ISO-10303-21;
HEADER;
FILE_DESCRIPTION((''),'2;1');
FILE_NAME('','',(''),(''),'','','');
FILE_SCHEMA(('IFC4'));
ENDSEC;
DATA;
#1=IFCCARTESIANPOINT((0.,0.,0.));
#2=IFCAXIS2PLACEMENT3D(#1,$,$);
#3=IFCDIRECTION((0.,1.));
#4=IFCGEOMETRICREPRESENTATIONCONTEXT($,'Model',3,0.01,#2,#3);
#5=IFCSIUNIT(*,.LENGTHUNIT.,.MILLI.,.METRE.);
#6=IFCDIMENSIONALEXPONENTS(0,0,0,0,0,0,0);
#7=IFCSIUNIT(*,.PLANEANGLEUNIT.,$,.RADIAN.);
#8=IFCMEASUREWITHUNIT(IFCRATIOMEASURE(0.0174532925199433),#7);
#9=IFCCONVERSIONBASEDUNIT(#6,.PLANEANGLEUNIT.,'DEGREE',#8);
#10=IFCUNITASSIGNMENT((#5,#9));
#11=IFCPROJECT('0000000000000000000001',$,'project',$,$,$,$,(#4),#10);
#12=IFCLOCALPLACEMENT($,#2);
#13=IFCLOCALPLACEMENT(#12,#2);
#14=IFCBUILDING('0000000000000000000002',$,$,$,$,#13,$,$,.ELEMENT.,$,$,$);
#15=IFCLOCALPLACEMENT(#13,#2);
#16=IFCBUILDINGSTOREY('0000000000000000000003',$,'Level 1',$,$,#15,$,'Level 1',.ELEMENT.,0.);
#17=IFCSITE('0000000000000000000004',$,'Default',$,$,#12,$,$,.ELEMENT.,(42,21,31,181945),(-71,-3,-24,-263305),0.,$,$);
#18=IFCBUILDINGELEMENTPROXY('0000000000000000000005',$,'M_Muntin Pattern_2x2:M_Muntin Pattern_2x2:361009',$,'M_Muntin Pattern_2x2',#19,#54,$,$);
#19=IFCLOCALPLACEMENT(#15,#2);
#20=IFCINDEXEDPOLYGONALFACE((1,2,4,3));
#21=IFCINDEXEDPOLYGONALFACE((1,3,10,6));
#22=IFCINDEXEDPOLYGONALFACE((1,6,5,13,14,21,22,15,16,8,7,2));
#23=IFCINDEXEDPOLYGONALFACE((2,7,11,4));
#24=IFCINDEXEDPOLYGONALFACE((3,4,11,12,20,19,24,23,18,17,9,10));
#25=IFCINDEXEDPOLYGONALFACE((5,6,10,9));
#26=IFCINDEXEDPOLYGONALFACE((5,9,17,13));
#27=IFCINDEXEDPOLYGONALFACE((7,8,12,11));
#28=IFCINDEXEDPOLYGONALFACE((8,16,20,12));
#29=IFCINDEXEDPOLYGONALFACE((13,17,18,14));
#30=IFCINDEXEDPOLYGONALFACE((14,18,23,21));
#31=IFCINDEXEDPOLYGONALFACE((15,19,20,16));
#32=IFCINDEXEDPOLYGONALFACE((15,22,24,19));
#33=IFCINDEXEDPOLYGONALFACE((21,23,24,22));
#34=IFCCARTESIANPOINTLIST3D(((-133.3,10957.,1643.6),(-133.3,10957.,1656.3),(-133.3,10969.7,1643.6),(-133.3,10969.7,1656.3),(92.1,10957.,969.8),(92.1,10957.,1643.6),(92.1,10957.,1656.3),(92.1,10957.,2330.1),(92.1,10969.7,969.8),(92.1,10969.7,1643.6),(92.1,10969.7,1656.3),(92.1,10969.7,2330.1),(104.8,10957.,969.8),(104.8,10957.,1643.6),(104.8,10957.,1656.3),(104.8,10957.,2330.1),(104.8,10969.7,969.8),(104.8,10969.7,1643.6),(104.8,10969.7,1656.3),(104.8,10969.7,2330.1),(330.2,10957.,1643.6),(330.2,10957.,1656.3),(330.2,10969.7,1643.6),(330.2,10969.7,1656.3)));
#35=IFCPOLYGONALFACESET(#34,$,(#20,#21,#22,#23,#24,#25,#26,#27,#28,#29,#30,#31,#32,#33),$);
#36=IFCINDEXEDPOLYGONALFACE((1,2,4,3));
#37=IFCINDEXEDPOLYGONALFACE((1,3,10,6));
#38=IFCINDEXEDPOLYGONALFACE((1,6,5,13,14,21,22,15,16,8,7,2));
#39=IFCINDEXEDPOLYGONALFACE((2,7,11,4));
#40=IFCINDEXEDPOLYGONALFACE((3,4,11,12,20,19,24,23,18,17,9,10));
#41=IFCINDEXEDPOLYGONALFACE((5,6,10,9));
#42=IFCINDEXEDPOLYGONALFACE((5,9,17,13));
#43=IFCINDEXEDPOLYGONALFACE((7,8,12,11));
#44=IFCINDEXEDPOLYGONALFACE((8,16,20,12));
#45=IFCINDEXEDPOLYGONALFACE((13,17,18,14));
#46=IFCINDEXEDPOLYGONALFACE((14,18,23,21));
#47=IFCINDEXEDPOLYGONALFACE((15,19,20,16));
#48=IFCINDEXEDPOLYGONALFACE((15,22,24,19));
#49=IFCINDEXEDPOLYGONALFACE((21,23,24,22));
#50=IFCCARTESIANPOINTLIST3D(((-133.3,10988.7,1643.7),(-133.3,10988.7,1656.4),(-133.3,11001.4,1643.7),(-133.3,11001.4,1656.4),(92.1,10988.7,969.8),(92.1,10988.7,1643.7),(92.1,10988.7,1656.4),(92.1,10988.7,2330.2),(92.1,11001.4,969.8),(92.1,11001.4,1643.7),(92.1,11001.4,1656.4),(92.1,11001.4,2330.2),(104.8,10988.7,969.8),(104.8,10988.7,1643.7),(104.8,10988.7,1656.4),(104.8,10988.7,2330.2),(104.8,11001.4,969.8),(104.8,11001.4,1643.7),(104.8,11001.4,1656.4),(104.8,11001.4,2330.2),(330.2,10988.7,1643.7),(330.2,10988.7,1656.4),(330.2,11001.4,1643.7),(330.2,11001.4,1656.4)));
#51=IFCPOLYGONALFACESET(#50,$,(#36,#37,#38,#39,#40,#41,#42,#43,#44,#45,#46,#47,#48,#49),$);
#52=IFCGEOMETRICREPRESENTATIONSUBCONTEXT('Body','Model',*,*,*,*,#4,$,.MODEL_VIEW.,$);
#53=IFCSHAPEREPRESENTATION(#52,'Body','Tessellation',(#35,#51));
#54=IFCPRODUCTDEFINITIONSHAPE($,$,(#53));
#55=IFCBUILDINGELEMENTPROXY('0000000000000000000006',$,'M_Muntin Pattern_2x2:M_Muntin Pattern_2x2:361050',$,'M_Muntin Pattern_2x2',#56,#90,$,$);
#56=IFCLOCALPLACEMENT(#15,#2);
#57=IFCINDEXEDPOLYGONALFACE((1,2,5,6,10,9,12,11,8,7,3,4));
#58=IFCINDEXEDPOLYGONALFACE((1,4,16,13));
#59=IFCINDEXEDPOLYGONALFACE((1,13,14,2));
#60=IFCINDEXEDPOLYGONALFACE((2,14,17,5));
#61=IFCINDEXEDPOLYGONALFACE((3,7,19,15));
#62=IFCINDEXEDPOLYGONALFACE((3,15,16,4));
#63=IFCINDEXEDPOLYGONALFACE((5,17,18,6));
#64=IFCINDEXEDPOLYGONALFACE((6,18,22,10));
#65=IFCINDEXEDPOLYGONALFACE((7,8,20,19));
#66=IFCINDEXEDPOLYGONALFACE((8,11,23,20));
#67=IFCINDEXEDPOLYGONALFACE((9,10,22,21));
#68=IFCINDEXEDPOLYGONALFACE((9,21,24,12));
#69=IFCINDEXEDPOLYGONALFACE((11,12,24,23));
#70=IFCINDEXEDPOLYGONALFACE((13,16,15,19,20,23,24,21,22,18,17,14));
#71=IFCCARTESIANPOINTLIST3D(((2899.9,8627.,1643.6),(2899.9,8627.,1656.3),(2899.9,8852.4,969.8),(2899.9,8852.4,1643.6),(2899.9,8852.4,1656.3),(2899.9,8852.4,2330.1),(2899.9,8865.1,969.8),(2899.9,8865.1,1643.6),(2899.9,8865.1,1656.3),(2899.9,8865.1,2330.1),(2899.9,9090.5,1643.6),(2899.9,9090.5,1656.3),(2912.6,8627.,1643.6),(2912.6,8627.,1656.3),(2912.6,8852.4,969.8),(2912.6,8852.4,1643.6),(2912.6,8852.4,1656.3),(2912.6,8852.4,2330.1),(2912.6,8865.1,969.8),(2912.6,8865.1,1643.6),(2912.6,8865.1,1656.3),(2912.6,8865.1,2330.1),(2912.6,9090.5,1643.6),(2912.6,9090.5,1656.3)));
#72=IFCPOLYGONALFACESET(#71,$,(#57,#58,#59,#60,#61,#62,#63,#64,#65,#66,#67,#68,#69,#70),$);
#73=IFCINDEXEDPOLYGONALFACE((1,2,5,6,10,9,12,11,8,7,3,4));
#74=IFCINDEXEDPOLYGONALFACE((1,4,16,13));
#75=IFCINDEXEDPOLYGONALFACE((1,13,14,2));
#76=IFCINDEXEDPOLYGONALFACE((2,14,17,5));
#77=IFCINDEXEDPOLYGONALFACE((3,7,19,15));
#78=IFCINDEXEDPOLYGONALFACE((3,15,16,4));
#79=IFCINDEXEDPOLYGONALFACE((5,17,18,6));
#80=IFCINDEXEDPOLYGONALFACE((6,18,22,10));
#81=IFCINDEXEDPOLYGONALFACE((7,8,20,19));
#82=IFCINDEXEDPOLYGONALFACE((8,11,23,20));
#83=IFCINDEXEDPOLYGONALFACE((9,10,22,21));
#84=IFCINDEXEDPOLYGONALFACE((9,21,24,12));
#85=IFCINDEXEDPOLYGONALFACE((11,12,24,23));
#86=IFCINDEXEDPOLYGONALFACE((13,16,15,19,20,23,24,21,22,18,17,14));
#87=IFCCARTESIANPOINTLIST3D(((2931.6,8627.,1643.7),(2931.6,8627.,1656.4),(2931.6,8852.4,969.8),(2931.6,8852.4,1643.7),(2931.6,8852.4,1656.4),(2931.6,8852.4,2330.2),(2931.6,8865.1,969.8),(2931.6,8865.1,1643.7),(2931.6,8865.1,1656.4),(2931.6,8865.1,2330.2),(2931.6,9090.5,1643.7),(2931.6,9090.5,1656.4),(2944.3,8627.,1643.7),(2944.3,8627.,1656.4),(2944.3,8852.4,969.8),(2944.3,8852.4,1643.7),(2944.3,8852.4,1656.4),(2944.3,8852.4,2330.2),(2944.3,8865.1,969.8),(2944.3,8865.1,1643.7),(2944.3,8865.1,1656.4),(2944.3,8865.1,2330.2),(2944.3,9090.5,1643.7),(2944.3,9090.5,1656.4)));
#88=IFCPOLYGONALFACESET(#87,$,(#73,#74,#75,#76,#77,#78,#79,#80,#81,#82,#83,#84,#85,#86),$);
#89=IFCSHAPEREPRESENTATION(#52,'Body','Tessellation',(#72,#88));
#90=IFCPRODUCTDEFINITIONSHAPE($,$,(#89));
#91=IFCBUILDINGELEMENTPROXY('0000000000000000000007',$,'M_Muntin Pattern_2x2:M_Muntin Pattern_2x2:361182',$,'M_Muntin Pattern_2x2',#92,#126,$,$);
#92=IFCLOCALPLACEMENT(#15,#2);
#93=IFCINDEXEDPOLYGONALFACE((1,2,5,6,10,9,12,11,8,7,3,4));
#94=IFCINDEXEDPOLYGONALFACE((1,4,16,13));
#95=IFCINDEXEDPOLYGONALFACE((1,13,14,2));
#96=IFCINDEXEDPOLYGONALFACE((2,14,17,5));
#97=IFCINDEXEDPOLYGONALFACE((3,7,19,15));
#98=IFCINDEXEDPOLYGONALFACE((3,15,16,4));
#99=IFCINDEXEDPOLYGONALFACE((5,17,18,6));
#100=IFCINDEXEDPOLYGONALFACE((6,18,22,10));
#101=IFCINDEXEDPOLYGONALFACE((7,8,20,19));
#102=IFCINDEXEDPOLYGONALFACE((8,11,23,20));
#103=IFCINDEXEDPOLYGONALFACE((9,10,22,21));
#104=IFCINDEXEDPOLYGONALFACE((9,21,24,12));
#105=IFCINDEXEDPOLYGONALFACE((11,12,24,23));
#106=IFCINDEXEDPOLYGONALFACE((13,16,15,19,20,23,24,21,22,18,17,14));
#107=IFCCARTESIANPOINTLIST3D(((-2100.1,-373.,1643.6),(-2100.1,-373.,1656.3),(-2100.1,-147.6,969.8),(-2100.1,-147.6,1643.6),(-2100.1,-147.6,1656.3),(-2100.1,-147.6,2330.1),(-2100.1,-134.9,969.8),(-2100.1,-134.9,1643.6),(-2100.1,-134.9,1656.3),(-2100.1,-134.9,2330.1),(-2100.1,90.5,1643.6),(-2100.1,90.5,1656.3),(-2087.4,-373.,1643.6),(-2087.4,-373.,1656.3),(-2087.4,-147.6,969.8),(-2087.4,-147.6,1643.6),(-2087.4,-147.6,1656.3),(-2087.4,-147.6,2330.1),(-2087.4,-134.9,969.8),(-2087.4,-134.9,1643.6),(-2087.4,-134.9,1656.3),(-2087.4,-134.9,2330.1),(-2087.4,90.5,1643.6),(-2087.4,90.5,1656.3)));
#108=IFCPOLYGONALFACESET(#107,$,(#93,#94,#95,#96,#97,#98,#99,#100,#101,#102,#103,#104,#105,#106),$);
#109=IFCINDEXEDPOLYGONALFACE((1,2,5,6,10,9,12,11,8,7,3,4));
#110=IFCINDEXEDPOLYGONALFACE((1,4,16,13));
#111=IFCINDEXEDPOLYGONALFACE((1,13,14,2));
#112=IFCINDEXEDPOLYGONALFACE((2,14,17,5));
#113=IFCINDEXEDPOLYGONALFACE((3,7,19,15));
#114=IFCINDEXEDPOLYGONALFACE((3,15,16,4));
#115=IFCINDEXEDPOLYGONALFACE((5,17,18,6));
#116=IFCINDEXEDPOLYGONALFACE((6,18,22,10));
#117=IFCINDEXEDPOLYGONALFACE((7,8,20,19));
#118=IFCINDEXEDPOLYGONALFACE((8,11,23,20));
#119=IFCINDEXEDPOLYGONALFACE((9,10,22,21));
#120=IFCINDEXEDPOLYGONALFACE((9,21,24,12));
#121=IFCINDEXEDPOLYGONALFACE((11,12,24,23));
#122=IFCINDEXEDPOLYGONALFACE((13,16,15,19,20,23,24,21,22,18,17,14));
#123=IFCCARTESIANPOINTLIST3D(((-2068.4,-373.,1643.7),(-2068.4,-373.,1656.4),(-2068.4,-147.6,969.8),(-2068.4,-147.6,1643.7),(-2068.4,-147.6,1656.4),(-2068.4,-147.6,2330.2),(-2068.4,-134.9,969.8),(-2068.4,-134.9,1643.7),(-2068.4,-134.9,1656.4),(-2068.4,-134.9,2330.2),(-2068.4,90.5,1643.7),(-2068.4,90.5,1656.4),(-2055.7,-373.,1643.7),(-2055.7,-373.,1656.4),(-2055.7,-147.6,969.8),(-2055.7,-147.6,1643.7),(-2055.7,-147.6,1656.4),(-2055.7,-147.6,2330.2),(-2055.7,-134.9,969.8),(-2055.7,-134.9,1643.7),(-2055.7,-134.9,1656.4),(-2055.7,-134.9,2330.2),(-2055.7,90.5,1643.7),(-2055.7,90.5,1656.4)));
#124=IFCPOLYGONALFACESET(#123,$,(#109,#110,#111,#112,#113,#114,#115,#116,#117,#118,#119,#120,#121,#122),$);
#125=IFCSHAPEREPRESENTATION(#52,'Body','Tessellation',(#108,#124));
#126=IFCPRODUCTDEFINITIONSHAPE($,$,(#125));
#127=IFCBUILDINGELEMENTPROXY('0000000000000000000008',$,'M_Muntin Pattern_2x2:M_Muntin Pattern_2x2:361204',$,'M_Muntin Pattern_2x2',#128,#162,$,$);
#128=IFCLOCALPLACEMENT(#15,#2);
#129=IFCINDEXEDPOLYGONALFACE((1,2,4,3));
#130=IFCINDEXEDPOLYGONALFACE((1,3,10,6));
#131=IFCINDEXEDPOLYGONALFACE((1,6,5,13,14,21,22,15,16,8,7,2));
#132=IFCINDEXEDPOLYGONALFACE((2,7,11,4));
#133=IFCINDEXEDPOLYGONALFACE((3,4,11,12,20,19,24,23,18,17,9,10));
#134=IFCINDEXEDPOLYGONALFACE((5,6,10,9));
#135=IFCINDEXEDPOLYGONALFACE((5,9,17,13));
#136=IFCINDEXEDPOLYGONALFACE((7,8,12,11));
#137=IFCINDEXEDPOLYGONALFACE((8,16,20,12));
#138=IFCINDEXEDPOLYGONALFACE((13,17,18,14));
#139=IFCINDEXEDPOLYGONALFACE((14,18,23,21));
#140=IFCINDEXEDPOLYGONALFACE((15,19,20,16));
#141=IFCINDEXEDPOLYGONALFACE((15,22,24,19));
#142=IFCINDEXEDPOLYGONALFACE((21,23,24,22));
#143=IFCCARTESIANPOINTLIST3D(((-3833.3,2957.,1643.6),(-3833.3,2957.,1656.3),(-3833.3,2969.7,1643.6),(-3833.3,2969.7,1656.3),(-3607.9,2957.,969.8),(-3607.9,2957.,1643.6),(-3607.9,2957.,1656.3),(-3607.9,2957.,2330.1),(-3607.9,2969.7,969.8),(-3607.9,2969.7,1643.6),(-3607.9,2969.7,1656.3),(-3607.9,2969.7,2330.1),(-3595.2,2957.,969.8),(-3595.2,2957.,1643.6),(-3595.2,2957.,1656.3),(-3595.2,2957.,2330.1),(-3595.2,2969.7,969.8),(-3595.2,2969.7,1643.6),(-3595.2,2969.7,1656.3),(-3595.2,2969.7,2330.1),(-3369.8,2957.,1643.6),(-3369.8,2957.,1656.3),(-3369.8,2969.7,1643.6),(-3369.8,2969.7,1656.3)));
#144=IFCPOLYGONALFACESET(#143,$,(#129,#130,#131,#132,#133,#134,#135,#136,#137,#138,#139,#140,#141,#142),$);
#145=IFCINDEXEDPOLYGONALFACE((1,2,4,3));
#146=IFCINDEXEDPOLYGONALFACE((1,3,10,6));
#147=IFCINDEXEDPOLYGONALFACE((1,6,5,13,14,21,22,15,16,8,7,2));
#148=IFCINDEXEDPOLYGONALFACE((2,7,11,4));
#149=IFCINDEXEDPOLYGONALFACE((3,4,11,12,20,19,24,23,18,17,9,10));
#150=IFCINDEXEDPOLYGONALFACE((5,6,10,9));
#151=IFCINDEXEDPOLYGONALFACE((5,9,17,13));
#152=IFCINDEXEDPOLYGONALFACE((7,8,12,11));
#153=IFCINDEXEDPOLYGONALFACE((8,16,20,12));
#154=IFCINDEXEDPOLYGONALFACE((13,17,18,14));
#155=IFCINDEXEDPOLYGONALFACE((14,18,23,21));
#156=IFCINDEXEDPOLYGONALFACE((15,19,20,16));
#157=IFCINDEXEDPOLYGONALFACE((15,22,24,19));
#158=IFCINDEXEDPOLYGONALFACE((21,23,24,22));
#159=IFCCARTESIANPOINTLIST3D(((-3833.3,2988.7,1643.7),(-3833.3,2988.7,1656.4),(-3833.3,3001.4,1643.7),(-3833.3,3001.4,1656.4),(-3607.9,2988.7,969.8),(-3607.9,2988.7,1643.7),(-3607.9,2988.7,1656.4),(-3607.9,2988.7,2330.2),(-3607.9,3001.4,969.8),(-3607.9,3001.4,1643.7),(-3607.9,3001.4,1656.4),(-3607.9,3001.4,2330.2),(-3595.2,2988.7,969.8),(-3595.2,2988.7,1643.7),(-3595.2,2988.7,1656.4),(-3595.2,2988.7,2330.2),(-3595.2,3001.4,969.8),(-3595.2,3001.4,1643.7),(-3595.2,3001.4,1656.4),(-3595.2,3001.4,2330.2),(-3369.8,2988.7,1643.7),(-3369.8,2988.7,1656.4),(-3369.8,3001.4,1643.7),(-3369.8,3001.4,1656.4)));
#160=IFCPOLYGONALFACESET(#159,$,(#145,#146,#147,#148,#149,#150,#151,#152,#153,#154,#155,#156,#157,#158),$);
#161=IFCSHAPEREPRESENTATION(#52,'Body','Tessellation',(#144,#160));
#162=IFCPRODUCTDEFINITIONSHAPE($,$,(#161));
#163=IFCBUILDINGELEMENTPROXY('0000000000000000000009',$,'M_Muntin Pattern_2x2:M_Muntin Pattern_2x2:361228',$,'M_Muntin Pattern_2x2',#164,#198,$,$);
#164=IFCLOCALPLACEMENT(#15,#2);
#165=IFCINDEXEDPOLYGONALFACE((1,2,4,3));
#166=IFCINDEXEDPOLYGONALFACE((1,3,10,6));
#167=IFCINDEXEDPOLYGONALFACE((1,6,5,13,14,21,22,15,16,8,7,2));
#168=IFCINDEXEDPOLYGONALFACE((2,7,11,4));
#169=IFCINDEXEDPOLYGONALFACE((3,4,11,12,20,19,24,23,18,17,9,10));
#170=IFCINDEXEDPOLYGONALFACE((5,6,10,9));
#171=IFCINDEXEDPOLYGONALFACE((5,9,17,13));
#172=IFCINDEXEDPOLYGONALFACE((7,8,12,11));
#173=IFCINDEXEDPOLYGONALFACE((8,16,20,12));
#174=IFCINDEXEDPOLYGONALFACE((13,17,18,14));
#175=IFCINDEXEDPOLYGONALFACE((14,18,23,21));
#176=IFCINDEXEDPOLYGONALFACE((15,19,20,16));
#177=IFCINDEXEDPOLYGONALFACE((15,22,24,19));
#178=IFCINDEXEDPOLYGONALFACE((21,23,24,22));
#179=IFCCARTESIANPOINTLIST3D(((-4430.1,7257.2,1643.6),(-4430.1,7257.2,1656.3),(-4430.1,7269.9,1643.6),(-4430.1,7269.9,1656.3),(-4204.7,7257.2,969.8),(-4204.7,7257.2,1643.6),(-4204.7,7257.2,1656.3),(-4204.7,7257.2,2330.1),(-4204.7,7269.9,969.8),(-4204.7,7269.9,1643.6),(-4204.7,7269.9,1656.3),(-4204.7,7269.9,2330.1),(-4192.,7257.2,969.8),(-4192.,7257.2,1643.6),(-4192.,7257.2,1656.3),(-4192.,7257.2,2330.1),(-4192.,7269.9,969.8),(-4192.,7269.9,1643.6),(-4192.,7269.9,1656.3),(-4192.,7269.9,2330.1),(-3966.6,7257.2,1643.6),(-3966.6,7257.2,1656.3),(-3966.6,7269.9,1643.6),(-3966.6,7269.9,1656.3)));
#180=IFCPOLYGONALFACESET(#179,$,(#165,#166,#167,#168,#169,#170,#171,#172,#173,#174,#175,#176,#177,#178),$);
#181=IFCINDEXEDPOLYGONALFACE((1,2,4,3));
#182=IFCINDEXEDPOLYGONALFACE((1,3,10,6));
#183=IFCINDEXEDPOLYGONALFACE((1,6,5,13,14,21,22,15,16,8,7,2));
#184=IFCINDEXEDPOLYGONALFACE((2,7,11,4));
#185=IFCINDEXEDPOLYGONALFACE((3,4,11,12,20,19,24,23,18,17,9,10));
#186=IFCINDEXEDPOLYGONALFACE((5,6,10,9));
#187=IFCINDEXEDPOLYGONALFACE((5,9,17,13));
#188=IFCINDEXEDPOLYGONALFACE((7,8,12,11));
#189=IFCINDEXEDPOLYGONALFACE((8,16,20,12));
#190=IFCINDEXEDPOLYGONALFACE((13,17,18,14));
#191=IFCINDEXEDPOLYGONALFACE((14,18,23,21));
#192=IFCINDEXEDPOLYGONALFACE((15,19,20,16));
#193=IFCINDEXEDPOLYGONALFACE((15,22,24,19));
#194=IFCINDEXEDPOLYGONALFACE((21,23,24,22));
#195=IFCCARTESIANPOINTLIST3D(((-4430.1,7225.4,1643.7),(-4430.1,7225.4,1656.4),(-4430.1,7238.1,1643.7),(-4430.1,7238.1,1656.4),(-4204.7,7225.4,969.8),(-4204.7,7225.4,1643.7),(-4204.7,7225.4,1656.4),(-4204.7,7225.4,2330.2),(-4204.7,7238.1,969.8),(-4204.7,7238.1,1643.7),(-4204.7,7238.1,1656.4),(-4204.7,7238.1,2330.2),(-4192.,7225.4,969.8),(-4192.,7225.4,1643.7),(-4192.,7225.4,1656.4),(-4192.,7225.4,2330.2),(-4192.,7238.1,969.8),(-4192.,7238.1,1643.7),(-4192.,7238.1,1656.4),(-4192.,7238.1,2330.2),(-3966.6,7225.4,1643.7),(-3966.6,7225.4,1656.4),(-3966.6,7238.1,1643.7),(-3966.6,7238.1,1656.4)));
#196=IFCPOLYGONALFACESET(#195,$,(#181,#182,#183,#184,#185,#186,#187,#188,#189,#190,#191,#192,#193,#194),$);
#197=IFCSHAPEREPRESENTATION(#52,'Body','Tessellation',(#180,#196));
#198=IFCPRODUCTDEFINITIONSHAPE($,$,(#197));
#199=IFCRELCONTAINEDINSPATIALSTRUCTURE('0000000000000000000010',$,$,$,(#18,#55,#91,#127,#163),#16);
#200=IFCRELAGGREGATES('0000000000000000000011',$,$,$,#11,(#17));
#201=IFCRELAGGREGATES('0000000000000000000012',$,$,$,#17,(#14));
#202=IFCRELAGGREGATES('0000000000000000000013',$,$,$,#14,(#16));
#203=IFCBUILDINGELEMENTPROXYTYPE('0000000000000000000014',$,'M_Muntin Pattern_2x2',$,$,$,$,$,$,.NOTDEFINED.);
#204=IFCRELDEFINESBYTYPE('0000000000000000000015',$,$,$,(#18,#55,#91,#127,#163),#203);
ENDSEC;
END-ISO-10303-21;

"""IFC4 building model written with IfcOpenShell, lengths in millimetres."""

from ifc_helpers import new_model, entity, si_unit, converted_unit, direction, frame, origin, place, context, subcontext, project, spatial, polyline, outline, extrude, source, transform, mapped, type_object, type_shapes, element, save


model = new_model("IFC4")

# Units and contexts
model_context = context("Model", 3, precision=0.01, world=origin(), true_north=direction((0.0, 1.0)))
body_context = subcontext(model_context, "Body", "Model", "MODEL_VIEW")
ifc_project = project(units=[si_unit("LENGTHUNIT", "METRE", prefix="MILLI"), converted_unit("PLANEANGLEUNIT", "DEGREE", entity("IfcRatioMeasure", 0.0174532925199433), si_unit("PLANEANGLEUNIT", "RADIAN"), dimensions=[0, 0, 0, 0, 0, 0, 0])], contexts=[model_context])

# Site, building, storey
site_placement = place(None, origin())
site = spatial("IfcSite", under=ifc_project, at=site_placement, Name="Default", CompositionType="ELEMENT", RefLatitude=(42, 21, 31, 181945), RefLongitude=(-71, -3, -24, -263305), RefElevation=0.0)
building_placement = place(site_placement, origin())
building = spatial("IfcBuilding", under=site, at=building_placement, CompositionType="ELEMENT")
storey_placement = place(building_placement, origin())
storey = spatial("IfcBuildingStorey", under=building, at=storey_placement, Name="Level 1", LongName="Level 1", CompositionType="ELEMENT", Elevation=0.0)

# Building element proxies
building_element_proxy_type_1 = type_object("IfcBuildingElementProxyType", Name="M_Muntin Pattern_2x2", PredefinedType="NOTDEFINED")
shared_shape_1 = source(origin(), body_context, "Body", "SweptSolid", [
    extrude(outline(polyline([(6.4, -6.4), (680.1, -6.4), (680.1, 6.3), (6.4, 6.3), (6.4, 231.7), (-6.3, 231.7), (-6.3, 6.3), (-680.2, 6.3), (-680.2, -6.4), (-6.3, -6.4), (-6.3, -231.7), (6.4, -231.7), (6.4, -6.4)])), frame((0.0, 9.5, 680.1), z_axis=(0.0, 1.0, 0.0), x_axis=(0.0, 0.0, 1.0)), (0.0, 0.0, 1.0), 12.7),
    extrude(outline(polyline([(6.4, -6.4), (680.2, -6.4), (680.2, 6.3), (6.4, 6.3), (6.4, 231.7), (-6.3, 231.7), (-6.3, 6.3), (-680.2, 6.3), (-680.2, -6.4), (-6.3, -6.4), (-6.3, -231.7), (6.4, -231.7), (6.4, -6.4)])), frame((0.0, -22.2, 680.2), z_axis=(0.0, 1.0, 0.0), x_axis=(0.0, 0.0, 1.0)), (0.0, 0.0, 1.0), 12.7),
])
type_shapes(building_element_proxy_type_1, [shared_shape_1])
for number, where, z_axis, x_axis, name in (
    (1, (98.5, 10979.2, 969.8), (0.0, 0.0, 1.0), (-1.0, 0.0, 0.0), "M_Muntin Pattern_2x2:M_Muntin Pattern_2x2:361009"),
    (2, (2922.1, 8858.7, 969.8), (0.0, 0.0, 1.0), (0.0, 1.0, 0.0), "M_Muntin Pattern_2x2:M_Muntin Pattern_2x2:361050"),
    (3, (-2077.9, -141.3, 969.8), (0.0, 0.0, 1.0), (0.0, 1.0, 0.0), "M_Muntin Pattern_2x2:M_Muntin Pattern_2x2:361182"),
    (4, (-3601.5, 2979.2, 969.8), (0.0, 0.0, 1.0), (-1.0, 0.0, 0.0), "M_Muntin Pattern_2x2:M_Muntin Pattern_2x2:361204"),
):
    element("IfcBuildingElementProxy", number, at=place(storey_placement, frame(where, z_axis=z_axis, x_axis=x_axis)), inside=storey, type_object=building_element_proxy_type_1, Name=name, ObjectType="M_Muntin Pattern_2x2", context=body_context, shape_type="MappedRepresentation", body=[
        mapped(shared_shape_1, transform((0.0, 0.0, 0.0), scale=1.0)),
    ])
for number, where, name in (
    (5, (-4198.4, 7247.6, 969.8), "M_Muntin Pattern_2x2:M_Muntin Pattern_2x2:361228"),
):
    element("IfcBuildingElementProxy", number, at=place(storey_placement, frame(where)), inside=storey, type_object=building_element_proxy_type_1, Name=name, ObjectType="M_Muntin Pattern_2x2", context=body_context, shape_type="MappedRepresentation", body=[
        mapped(shared_shape_1, transform((0.0, 0.0, 0.0), scale=1.0)),
    ])

save(model, "model.ifc")
